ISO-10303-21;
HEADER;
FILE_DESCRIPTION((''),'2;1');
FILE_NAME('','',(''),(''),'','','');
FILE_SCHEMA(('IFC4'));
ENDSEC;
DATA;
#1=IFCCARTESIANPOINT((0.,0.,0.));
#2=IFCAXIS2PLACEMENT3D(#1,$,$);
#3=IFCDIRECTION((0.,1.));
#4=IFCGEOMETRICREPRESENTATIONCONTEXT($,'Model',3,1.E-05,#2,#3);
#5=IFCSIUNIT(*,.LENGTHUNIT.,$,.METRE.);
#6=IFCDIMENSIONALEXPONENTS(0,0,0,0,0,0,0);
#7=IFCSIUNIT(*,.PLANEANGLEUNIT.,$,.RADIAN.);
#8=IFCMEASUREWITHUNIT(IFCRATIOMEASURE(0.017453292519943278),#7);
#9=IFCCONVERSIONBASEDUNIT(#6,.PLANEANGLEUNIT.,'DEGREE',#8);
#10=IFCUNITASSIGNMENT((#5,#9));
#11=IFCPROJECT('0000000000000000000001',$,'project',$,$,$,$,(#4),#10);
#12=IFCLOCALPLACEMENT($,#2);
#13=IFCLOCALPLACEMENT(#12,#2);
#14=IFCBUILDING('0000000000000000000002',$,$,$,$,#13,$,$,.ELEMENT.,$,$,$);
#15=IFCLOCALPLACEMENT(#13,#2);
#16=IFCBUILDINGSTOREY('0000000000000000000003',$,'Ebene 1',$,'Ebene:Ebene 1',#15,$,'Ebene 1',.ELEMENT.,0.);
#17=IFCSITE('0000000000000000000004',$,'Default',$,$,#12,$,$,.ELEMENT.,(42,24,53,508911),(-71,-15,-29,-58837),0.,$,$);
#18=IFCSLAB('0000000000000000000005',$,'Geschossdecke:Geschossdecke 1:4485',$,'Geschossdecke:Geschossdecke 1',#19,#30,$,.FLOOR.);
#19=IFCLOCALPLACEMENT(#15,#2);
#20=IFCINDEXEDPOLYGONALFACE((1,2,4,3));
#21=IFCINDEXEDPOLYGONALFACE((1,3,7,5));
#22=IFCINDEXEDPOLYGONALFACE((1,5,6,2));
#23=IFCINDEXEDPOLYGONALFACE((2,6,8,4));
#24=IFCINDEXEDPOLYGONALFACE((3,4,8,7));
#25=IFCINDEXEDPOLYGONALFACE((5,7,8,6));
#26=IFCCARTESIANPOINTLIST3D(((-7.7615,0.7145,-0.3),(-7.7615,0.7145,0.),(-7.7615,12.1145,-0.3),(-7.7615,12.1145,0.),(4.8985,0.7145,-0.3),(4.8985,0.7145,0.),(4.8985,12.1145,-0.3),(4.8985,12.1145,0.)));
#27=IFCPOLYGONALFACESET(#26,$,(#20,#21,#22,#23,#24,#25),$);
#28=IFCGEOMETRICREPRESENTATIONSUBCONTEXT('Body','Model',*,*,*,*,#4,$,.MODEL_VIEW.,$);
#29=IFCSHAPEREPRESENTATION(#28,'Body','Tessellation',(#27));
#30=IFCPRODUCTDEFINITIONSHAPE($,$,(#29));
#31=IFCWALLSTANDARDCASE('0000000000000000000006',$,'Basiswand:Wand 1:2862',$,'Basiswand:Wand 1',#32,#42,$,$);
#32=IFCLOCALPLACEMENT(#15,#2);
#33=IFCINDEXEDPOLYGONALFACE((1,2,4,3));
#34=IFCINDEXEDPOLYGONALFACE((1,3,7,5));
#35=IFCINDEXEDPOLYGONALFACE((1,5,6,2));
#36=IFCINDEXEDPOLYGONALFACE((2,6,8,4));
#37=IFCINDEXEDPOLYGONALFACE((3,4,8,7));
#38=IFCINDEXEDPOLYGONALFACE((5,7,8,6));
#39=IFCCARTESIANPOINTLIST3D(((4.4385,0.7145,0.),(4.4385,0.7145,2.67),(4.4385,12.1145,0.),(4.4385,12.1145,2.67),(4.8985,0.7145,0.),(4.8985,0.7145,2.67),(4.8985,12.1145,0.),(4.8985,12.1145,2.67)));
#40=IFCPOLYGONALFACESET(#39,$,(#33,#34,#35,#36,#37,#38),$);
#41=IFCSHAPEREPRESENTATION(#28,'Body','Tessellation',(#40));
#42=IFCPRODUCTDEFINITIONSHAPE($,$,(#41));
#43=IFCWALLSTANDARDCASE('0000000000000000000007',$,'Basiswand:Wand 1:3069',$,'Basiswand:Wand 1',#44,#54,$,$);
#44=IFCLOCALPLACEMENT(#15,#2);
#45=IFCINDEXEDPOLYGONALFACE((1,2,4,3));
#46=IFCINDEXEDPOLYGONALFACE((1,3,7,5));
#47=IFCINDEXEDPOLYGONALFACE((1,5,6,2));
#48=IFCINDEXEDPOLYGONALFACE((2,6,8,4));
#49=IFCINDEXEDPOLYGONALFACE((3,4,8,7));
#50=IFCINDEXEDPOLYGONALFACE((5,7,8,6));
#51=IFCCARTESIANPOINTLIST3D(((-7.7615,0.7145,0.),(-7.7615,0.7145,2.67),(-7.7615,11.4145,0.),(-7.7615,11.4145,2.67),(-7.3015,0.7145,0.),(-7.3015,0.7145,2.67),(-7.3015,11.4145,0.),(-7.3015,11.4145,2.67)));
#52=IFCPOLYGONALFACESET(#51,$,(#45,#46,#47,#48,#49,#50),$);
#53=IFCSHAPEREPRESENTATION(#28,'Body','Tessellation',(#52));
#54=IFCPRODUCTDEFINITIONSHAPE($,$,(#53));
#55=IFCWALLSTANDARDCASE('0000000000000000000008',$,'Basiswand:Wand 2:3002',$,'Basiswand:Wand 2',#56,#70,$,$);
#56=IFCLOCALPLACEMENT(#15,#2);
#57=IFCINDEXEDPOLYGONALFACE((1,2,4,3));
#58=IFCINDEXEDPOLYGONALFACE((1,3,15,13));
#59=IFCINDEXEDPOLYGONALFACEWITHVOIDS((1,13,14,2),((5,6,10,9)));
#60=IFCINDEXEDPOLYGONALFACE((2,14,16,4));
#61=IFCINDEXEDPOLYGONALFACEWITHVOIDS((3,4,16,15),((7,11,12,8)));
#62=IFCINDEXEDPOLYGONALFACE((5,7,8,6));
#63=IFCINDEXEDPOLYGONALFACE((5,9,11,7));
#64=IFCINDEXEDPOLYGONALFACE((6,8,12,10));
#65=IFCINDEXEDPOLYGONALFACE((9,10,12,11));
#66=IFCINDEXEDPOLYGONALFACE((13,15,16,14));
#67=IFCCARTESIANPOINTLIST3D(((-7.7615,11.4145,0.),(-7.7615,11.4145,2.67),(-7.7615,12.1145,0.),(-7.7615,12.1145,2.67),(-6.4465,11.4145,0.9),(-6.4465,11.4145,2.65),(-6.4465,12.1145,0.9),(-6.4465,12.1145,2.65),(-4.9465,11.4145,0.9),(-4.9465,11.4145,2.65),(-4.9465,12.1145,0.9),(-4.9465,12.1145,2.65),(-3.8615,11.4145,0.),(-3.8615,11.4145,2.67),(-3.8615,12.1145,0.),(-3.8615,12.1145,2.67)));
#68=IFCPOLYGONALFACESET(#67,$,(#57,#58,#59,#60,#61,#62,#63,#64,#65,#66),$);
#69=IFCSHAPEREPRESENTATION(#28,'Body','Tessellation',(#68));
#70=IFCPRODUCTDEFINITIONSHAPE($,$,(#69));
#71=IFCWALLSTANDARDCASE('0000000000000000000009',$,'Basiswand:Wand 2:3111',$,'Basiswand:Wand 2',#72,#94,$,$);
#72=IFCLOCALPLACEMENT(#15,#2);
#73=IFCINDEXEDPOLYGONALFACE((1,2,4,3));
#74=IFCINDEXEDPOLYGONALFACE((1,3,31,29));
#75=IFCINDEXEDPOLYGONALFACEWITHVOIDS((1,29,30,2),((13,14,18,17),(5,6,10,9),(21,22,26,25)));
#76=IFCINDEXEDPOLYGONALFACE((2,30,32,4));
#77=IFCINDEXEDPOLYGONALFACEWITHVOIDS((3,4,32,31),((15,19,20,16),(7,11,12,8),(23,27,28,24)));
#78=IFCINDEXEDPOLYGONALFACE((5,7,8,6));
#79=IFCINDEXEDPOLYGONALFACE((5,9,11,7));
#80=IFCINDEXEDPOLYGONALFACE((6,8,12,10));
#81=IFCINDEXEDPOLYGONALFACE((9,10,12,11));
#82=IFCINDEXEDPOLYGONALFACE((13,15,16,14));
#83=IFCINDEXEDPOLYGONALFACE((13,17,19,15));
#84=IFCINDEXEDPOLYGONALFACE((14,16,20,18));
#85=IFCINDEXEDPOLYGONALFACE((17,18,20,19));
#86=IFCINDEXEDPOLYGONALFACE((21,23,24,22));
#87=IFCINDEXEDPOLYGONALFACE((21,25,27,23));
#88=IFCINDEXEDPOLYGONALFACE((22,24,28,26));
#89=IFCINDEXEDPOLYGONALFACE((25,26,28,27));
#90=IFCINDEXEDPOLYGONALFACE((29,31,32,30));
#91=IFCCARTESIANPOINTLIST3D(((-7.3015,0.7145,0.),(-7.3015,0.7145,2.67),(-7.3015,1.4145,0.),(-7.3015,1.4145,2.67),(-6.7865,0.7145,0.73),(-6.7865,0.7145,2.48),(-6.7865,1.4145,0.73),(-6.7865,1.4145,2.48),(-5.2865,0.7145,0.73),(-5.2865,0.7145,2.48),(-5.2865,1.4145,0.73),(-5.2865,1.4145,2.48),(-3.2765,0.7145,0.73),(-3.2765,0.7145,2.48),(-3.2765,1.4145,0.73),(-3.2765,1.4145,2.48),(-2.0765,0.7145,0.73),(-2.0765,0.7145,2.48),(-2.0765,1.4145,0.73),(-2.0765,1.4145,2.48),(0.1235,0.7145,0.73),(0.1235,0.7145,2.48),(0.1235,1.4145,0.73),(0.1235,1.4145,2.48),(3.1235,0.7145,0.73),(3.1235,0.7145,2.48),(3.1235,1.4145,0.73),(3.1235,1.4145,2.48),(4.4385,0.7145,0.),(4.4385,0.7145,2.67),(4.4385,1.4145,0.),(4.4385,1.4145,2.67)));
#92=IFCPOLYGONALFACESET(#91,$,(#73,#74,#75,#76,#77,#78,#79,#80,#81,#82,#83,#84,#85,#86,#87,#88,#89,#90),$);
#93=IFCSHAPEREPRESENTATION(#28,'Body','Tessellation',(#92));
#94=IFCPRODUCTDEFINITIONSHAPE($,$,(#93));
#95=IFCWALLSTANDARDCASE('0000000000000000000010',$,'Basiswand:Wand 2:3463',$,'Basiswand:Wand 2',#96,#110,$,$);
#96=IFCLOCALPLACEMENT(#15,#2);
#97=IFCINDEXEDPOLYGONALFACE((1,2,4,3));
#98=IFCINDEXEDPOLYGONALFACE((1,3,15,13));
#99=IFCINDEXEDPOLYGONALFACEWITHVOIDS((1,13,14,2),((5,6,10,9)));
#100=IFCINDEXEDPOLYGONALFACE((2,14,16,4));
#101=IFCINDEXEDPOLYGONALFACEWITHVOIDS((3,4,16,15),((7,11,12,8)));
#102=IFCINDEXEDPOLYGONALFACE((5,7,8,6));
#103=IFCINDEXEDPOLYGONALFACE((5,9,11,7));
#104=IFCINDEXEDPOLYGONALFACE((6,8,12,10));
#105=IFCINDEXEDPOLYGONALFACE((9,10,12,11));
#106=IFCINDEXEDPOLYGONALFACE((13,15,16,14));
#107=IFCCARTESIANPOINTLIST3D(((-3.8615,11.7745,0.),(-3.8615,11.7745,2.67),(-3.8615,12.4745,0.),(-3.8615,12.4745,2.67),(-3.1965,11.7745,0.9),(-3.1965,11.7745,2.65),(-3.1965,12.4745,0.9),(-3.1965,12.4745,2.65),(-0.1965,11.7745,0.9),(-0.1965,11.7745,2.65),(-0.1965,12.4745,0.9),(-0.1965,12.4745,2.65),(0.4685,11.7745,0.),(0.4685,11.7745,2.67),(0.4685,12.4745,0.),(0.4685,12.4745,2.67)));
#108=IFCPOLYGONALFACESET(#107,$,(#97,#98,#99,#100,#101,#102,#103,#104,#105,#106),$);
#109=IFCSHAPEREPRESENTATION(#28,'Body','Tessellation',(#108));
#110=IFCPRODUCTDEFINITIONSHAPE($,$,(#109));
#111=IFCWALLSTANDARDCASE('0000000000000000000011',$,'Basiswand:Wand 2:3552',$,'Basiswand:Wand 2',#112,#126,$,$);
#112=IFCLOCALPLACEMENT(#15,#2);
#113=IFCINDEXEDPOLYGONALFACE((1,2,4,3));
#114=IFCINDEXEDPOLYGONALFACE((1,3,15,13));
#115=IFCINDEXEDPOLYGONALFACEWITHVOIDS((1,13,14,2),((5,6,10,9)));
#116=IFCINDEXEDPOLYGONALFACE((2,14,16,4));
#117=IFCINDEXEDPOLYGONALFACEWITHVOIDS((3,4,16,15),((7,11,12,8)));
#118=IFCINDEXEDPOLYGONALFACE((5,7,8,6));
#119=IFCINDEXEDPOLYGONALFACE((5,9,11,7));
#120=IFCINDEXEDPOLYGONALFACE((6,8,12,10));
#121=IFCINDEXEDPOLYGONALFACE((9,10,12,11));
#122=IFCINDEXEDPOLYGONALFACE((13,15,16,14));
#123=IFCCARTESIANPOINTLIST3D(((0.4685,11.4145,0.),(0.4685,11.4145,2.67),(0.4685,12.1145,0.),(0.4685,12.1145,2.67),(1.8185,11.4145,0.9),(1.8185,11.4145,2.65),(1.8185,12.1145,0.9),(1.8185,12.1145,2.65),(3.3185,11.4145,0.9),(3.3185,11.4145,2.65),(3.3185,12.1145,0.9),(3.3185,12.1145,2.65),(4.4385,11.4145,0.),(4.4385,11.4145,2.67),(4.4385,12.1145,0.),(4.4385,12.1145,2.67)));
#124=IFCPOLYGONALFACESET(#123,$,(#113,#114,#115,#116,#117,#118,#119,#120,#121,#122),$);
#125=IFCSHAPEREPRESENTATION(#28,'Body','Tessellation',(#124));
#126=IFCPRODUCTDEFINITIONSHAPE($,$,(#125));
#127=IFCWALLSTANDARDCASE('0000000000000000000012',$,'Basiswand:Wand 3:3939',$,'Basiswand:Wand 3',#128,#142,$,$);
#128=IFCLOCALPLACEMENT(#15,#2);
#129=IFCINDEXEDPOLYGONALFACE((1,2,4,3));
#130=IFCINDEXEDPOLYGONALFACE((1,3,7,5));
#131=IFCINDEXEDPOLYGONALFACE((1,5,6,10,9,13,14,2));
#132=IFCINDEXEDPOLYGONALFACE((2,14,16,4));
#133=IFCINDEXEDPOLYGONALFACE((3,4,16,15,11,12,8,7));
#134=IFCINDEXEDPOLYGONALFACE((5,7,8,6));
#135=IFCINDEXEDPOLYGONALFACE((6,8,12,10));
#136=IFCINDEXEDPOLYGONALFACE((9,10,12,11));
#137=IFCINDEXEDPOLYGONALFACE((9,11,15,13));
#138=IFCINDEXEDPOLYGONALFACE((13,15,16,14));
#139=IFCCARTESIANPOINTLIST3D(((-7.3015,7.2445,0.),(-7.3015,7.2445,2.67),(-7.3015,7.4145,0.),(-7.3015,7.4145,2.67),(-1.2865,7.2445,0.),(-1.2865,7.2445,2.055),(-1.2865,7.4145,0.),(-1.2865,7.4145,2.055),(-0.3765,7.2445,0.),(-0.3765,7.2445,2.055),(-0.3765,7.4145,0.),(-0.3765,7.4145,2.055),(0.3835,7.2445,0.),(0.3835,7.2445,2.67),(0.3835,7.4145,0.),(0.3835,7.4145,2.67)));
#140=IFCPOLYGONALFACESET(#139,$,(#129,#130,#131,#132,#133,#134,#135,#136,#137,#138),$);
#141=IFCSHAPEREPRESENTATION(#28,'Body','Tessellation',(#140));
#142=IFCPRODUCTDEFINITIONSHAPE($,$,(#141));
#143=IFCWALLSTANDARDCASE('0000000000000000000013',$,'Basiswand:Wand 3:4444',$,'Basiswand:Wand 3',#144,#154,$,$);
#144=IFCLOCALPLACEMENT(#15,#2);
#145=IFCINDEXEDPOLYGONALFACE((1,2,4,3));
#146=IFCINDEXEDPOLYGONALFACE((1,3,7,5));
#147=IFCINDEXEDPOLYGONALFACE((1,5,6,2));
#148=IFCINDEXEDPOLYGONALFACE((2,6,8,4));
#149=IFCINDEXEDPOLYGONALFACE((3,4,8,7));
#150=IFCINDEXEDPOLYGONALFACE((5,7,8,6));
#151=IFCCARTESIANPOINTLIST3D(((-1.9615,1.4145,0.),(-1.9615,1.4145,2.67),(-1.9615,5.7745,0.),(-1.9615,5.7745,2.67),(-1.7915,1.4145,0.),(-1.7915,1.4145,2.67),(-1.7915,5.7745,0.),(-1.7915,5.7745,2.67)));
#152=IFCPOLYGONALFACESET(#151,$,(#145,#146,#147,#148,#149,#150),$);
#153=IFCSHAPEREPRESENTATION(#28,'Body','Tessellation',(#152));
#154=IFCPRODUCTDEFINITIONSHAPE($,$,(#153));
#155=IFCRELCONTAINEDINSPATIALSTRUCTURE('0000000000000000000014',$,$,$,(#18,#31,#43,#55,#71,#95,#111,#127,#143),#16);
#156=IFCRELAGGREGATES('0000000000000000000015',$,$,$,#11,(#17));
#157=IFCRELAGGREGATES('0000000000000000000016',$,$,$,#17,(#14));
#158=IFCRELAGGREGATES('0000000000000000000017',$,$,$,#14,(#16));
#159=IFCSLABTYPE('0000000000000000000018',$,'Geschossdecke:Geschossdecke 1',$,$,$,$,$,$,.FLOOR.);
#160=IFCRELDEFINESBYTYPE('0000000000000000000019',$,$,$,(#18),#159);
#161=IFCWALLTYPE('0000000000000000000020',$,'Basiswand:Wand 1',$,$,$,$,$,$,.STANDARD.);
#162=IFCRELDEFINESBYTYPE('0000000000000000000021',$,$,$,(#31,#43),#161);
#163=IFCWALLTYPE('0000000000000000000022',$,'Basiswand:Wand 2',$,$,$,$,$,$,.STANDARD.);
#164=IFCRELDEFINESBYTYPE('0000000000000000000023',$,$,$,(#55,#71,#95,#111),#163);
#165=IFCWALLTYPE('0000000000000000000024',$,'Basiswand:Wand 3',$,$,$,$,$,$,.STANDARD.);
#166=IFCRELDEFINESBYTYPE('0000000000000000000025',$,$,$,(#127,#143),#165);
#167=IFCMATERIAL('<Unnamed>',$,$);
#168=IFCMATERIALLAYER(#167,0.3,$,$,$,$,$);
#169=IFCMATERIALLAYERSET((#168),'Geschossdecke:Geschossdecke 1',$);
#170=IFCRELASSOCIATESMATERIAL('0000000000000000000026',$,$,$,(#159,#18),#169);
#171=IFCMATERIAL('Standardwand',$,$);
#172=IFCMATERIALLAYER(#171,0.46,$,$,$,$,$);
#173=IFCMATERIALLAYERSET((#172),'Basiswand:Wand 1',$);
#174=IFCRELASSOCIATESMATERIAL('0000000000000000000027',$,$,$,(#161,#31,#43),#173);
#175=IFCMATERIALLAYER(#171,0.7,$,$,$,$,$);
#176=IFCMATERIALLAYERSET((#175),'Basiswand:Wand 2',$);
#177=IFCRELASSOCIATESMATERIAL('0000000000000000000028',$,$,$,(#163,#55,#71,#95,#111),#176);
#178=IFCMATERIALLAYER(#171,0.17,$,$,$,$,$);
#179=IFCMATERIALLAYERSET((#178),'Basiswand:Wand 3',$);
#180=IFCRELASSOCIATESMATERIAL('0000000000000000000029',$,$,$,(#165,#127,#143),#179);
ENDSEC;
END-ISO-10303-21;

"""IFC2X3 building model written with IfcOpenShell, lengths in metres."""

from ifc_helpers import new_model, entity, si_unit, converted_unit, direction, frame, frame_2d, origin, origin_2d_with_axis, place, context, subcontext, project, spatial, rectangle, extrude, material, layer, layer_set, layer_usage, type_object, element, save


model = new_model("IFC2X3")

# Units and contexts
model_context = context("Model", 3, precision=1e-05, world=origin(), true_north=direction((0.0, 1.0)))
body_context = subcontext(model_context, "Body", "Model", "MODEL_VIEW")
ifc_project = project(units=[si_unit("LENGTHUNIT", "METRE"), converted_unit("PLANEANGLEUNIT", "DEGREE", entity("IfcRatioMeasure", 0.017453292519943278), si_unit("PLANEANGLEUNIT", "RADIAN"), dimensions=[0, 0, 0, 0, 0, 0, 0])], contexts=[model_context])

# Site, building, storey
site_placement = place(None, origin())
site = spatial("IfcSite", under=ifc_project, at=site_placement, Name="Default", CompositionType="ELEMENT", RefLatitude=(42, 24, 53, 508911), RefLongitude=(-71, -15, -29, -58837), RefElevation=0.0)
building_placement = place(site_placement, origin())
building = spatial("IfcBuilding", under=site, at=building_placement, CompositionType="ELEMENT")
storey_placement = place(building_placement, origin())
storey = spatial("IfcBuildingStorey", under=building, at=storey_placement, Name="Ebene 1", ObjectType="Ebene:Ebene 1", LongName="Ebene 1", CompositionType="ELEMENT", Elevation=0.0)

# Slab
ifc_material_1 = material(Name="<Unnamed>")
ifc_layer_1 = layer(ifc_material_1, 0.3)
ifc_layer_set_1 = layer_set([ifc_layer_1], Name="Geschossdecke:Geschossdecke 1")
ifc_layer_usage_1 = layer_usage(ifc_layer_set_1, "AXIS3", "POSITIVE", 0.0)
slab_type = type_object("IfcSlabType", Name="Geschossdecke:Geschossdecke 1", PredefinedType="FLOOR", material=ifc_layer_set_1)
slab_1_placement = place(storey_placement, origin())
element("IfcSlab", 1, at=slab_1_placement, inside=storey, type_object=slab_type, material=ifc_layer_usage_1, Name="Geschossdecke:Geschossdecke 1:4485", ObjectType="Geschossdecke:Geschossdecke 1", PredefinedType="FLOOR", context=body_context, shape_type="SweptSolid", body=[
    extrude(rectangle(XDim=11.4, YDim=12.66, at=origin_2d_with_axis()), frame((-1.4315, 6.4145, 0.0), z_axis=(0.0, 0.0, -1.0), x_axis=(0.0, 1.0, 0.0)), (0.0, 0.0, 1.0), 0.3),
])

# Walls
ifc_material_2 = material(Name="Standardwand")
ifc_layer_2 = layer(ifc_material_2, 0.46)
ifc_layer_set_2 = layer_set([ifc_layer_2], Name="Basiswand:Wand 1")
ifc_layer_usage_2 = layer_usage(ifc_layer_set_2, "AXIS2", "NEGATIVE", 0.23)
wall_type_1 = type_object("IfcWallType", Name="Basiswand:Wand 1", PredefinedType="STANDARD", material=ifc_layer_set_2)
wall_1_placement = place(storey_placement, frame((4.6685, 0.7145, 0.0), z_axis=(0.0, 0.0, 1.0), x_axis=(0.0, 1.0, 0.0)))
element("IfcWallStandardCase", 2, at=wall_1_placement, inside=storey, type_object=wall_type_1, material=ifc_layer_usage_2, Name="Basiswand:Wand 1:2862", ObjectType="Basiswand:Wand 1", context=body_context, shape_type="SweptSolid", body=[
    extrude(rectangle(XDim=11.4, YDim=0.46, at=frame_2d((5.7, 0.0), x_axis=(-1.0, 0.0))), origin(), (0.0, 0.0, 1.0), 2.67),
])
wall_2_placement = place(storey_placement, frame((-7.5315, 11.4145, 0.0), z_axis=(0.0, 0.0, 1.0), x_axis=(0.0, -1.0, 0.0)))
element("IfcWallStandardCase", 3, at=wall_2_placement, inside=storey, type_object=wall_type_1, material=ifc_layer_usage_2, Name="Basiswand:Wand 1:3069", ObjectType="Basiswand:Wand 1", context=body_context, shape_type="SweptSolid", body=[
    extrude(rectangle(XDim=10.7, YDim=0.46, at=frame_2d((5.35, 0.0), x_axis=(-1.0, 0.0))), origin(), (0.0, 0.0, 1.0), 2.67),
])

# Wall, opening
ifc_layer_3 = layer(ifc_material_2, 0.7)
ifc_layer_set_3 = layer_set([ifc_layer_3], Name="Basiswand:Wand 2")
ifc_layer_usage_3 = layer_usage(ifc_layer_set_3, "AXIS2", "NEGATIVE", 0.35)
wall_type_2 = type_object("IfcWallType", Name="Basiswand:Wand 2", PredefinedType="STANDARD", material=ifc_layer_set_3)
wall_3_placement = place(storey_placement, frame((-3.8615, 11.7645, 0.0), z_axis=(0.0, 0.0, 1.0), x_axis=(-1.0, 0.0, 0.0)))
wall_3 = element("IfcWallStandardCase", 4, at=wall_3_placement, inside=storey, type_object=wall_type_2, material=ifc_layer_usage_3, Name="Basiswand:Wand 2:3002", ObjectType="Basiswand:Wand 2", context=body_context, shape_type="SweptSolid", body=[
    extrude(rectangle(XDim=3.9, YDim=0.7, at=frame_2d((1.95, 0.0), x_axis=(-1.0, 0.0))), origin(), (0.0, 0.0, 1.0), 2.67),
])
opening_1_placement = place(wall_3_placement, frame((1.085, -0.35, 0.9)))
element("IfcOpeningElement", 5, at=opening_1_placement, cuts=wall_3, ObjectType="Opening", context=body_context, shape_type="SweptSolid", body=[
    extrude(rectangle(XDim=1.75, YDim=1.5, at=frame_2d((0.875, 0.75), x_axis=(1.0, 0.0))), frame((0.0, 0.0, 0.0), z_axis=(0.0, 1.0, 0.0), x_axis=(0.0, 0.0, 1.0)), (0.0, 0.0, 1.0), 0.7),
])

# Wall, openings
wall_4_placement = place(storey_placement, frame((-7.3015, 1.0645, 0.0)))
wall_4 = element("IfcWallStandardCase", 6, at=wall_4_placement, inside=storey, type_object=wall_type_2, material=ifc_layer_usage_3, Name="Basiswand:Wand 2:3111", ObjectType="Basiswand:Wand 2", context=body_context, shape_type="SweptSolid", body=[
    extrude(rectangle(XDim=11.74, YDim=0.7, at=frame_2d((5.87, 0.0), x_axis=(-1.0, 0.0))), origin(), (0.0, 0.0, 1.0), 2.67),
])
opening_2_placement = place(wall_4_placement, frame((5.225, 0.35, 0.73)))
element("IfcOpeningElement", 7, at=opening_2_placement, cuts=wall_4, ObjectType="Opening", context=body_context, shape_type="SweptSolid", body=[
    extrude(rectangle(XDim=1.75, YDim=1.2, at=frame_2d((0.875, 0.6), x_axis=(1.0, 0.0))), frame((0.0, 0.0, 0.0), z_axis=(0.0, -1.0, 0.0), x_axis=(0.0, 0.0, 1.0)), (0.0, 0.0, 1.0), 0.7),
])
opening_3_placement = place(wall_4_placement, frame((2.015, 0.35, 0.73)))
element("IfcOpeningElement", 8, at=opening_3_placement, cuts=wall_4, ObjectType="Opening", context=body_context, shape_type="SweptSolid", body=[
    extrude(rectangle(XDim=1.75, YDim=1.5, at=frame_2d((0.875, 0.75), x_axis=(1.0, 0.0))), frame((0.0, 0.0, 0.0), z_axis=(0.0, -1.0, 0.0), x_axis=(0.0, 0.0, 1.0)), (0.0, 0.0, 1.0), 0.7),
])
opening_4_placement = place(wall_4_placement, frame((10.425, 0.35, 0.73)))
element("IfcOpeningElement", 9, at=opening_4_placement, cuts=wall_4, ObjectType="Opening", context=body_context, shape_type="SweptSolid", body=[
    extrude(rectangle(XDim=1.75, YDim=3.0, at=frame_2d((0.875, 1.5), x_axis=(1.0, 0.0))), frame((0.0, 0.0, 0.0), z_axis=(0.0, -1.0, 0.0), x_axis=(0.0, 0.0, 1.0)), (0.0, 0.0, 1.0), 0.7),
])

# Walls, openings
wall_5_placement = place(storey_placement, frame((-3.8615, 12.1245, 0.0)))
wall_5 = element("IfcWallStandardCase", 10, at=wall_5_placement, inside=storey, type_object=wall_type_2, material=ifc_layer_usage_3, Name="Basiswand:Wand 2:3463", ObjectType="Basiswand:Wand 2", context=body_context, shape_type="SweptSolid", body=[
    extrude(rectangle(XDim=4.33, YDim=0.7, at=frame_2d((2.165, 0.0), x_axis=(-1.0, 0.0))), origin(), (0.0, 0.0, 1.0), 2.67),
])
opening_5_placement = place(wall_5_placement, frame((0.665, -0.35, 0.9)))
element("IfcOpeningElement", 11, at=opening_5_placement, cuts=wall_5, ObjectType="Opening", context=body_context, shape_type="SweptSolid", body=[
    extrude(rectangle(XDim=1.75, YDim=3.0, at=frame_2d((0.875, 1.5), x_axis=(1.0, 0.0))), frame((0.0, 0.0, 0.0), z_axis=(0.0, 1.0, 0.0), x_axis=(0.0, 0.0, 1.0)), (0.0, 0.0, 1.0), 0.7),
])
wall_6_placement = place(storey_placement, frame((0.4685, 11.7645, 0.0)))
wall_6 = element("IfcWallStandardCase", 12, at=wall_6_placement, inside=storey, type_object=wall_type_2, material=ifc_layer_usage_3, Name="Basiswand:Wand 2:3552", ObjectType="Basiswand:Wand 2", context=body_context, shape_type="SweptSolid", body=[
    extrude(rectangle(XDim=3.97, YDim=0.7, at=frame_2d((1.985, 0.0), x_axis=(-1.0, 0.0))), origin(), (0.0, 0.0, 1.0), 2.67),
])
opening_6_placement = place(wall_6_placement, frame((2.85, 0.35, 0.9)))
element("IfcOpeningElement", 13, at=opening_6_placement, cuts=wall_6, ObjectType="Opening", context=body_context, shape_type="SweptSolid", body=[
    extrude(rectangle(XDim=1.75, YDim=1.5, at=frame_2d((0.875, 0.75), x_axis=(1.0, 0.0))), frame((0.0, 0.0, 0.0), z_axis=(0.0, -1.0, 0.0), x_axis=(0.0, 0.0, 1.0)), (0.0, 0.0, 1.0), 0.7),
])
ifc_layer_4 = layer(ifc_material_2, 0.17)
ifc_layer_set_4 = layer_set([ifc_layer_4], Name="Basiswand:Wand 3")
ifc_layer_usage_4 = layer_usage(ifc_layer_set_4, "AXIS2", "NEGATIVE", 0.085)
wall_type_3 = type_object("IfcWallType", Name="Basiswand:Wand 3", PredefinedType="STANDARD", material=ifc_layer_set_4)
wall_7_placement = place(storey_placement, frame((0.3835, 7.3295, 0.0), z_axis=(0.0, 0.0, 1.0), x_axis=(-1.0, 0.0, 0.0)))
wall_7 = element("IfcWallStandardCase", 14, at=wall_7_placement, inside=storey, type_object=wall_type_3, material=ifc_layer_usage_4, Name="Basiswand:Wand 3:3939", ObjectType="Basiswand:Wand 3", context=body_context, shape_type="SweptSolid", body=[
    extrude(rectangle(XDim=7.685, YDim=0.17, at=frame_2d((3.8425, 0.0), x_axis=(-1.0, 0.0))), origin(), (0.0, 0.0, 1.0), 2.67),
])
opening_7_placement = place(wall_7_placement, frame((1.67, 0.085, -0.18)))
element("IfcOpeningElement", 15, at=opening_7_placement, cuts=wall_7, ObjectType="Opening", context=body_context, shape_type="SweptSolid", body=[
    extrude(rectangle(XDim=2.235, YDim=0.91, at=frame_2d((1.1175, 0.455), x_axis=(-1.0, 0.0))), frame((0.0, 0.0, 0.0), z_axis=(0.0, -1.0, 0.0), x_axis=(0.0, 0.0, 1.0)), (0.0, 0.0, 1.0), 0.17),
])

# Wall
wall_8_placement = place(storey_placement, frame((-1.8765, 5.7745, 0.0), z_axis=(0.0, 0.0, 1.0), x_axis=(0.0, -1.0, 0.0)))
element("IfcWallStandardCase", 16, at=wall_8_placement, inside=storey, type_object=wall_type_3, material=ifc_layer_usage_4, Name="Basiswand:Wand 3:4444", ObjectType="Basiswand:Wand 3", context=body_context, shape_type="SweptSolid", body=[
    extrude(rectangle(XDim=4.36, YDim=0.17, at=frame_2d((2.18, 0.0), x_axis=(-1.0, 0.0))), origin(), (0.0, 0.0, 1.0), 2.67),
])

save(model, "model.ifc")
